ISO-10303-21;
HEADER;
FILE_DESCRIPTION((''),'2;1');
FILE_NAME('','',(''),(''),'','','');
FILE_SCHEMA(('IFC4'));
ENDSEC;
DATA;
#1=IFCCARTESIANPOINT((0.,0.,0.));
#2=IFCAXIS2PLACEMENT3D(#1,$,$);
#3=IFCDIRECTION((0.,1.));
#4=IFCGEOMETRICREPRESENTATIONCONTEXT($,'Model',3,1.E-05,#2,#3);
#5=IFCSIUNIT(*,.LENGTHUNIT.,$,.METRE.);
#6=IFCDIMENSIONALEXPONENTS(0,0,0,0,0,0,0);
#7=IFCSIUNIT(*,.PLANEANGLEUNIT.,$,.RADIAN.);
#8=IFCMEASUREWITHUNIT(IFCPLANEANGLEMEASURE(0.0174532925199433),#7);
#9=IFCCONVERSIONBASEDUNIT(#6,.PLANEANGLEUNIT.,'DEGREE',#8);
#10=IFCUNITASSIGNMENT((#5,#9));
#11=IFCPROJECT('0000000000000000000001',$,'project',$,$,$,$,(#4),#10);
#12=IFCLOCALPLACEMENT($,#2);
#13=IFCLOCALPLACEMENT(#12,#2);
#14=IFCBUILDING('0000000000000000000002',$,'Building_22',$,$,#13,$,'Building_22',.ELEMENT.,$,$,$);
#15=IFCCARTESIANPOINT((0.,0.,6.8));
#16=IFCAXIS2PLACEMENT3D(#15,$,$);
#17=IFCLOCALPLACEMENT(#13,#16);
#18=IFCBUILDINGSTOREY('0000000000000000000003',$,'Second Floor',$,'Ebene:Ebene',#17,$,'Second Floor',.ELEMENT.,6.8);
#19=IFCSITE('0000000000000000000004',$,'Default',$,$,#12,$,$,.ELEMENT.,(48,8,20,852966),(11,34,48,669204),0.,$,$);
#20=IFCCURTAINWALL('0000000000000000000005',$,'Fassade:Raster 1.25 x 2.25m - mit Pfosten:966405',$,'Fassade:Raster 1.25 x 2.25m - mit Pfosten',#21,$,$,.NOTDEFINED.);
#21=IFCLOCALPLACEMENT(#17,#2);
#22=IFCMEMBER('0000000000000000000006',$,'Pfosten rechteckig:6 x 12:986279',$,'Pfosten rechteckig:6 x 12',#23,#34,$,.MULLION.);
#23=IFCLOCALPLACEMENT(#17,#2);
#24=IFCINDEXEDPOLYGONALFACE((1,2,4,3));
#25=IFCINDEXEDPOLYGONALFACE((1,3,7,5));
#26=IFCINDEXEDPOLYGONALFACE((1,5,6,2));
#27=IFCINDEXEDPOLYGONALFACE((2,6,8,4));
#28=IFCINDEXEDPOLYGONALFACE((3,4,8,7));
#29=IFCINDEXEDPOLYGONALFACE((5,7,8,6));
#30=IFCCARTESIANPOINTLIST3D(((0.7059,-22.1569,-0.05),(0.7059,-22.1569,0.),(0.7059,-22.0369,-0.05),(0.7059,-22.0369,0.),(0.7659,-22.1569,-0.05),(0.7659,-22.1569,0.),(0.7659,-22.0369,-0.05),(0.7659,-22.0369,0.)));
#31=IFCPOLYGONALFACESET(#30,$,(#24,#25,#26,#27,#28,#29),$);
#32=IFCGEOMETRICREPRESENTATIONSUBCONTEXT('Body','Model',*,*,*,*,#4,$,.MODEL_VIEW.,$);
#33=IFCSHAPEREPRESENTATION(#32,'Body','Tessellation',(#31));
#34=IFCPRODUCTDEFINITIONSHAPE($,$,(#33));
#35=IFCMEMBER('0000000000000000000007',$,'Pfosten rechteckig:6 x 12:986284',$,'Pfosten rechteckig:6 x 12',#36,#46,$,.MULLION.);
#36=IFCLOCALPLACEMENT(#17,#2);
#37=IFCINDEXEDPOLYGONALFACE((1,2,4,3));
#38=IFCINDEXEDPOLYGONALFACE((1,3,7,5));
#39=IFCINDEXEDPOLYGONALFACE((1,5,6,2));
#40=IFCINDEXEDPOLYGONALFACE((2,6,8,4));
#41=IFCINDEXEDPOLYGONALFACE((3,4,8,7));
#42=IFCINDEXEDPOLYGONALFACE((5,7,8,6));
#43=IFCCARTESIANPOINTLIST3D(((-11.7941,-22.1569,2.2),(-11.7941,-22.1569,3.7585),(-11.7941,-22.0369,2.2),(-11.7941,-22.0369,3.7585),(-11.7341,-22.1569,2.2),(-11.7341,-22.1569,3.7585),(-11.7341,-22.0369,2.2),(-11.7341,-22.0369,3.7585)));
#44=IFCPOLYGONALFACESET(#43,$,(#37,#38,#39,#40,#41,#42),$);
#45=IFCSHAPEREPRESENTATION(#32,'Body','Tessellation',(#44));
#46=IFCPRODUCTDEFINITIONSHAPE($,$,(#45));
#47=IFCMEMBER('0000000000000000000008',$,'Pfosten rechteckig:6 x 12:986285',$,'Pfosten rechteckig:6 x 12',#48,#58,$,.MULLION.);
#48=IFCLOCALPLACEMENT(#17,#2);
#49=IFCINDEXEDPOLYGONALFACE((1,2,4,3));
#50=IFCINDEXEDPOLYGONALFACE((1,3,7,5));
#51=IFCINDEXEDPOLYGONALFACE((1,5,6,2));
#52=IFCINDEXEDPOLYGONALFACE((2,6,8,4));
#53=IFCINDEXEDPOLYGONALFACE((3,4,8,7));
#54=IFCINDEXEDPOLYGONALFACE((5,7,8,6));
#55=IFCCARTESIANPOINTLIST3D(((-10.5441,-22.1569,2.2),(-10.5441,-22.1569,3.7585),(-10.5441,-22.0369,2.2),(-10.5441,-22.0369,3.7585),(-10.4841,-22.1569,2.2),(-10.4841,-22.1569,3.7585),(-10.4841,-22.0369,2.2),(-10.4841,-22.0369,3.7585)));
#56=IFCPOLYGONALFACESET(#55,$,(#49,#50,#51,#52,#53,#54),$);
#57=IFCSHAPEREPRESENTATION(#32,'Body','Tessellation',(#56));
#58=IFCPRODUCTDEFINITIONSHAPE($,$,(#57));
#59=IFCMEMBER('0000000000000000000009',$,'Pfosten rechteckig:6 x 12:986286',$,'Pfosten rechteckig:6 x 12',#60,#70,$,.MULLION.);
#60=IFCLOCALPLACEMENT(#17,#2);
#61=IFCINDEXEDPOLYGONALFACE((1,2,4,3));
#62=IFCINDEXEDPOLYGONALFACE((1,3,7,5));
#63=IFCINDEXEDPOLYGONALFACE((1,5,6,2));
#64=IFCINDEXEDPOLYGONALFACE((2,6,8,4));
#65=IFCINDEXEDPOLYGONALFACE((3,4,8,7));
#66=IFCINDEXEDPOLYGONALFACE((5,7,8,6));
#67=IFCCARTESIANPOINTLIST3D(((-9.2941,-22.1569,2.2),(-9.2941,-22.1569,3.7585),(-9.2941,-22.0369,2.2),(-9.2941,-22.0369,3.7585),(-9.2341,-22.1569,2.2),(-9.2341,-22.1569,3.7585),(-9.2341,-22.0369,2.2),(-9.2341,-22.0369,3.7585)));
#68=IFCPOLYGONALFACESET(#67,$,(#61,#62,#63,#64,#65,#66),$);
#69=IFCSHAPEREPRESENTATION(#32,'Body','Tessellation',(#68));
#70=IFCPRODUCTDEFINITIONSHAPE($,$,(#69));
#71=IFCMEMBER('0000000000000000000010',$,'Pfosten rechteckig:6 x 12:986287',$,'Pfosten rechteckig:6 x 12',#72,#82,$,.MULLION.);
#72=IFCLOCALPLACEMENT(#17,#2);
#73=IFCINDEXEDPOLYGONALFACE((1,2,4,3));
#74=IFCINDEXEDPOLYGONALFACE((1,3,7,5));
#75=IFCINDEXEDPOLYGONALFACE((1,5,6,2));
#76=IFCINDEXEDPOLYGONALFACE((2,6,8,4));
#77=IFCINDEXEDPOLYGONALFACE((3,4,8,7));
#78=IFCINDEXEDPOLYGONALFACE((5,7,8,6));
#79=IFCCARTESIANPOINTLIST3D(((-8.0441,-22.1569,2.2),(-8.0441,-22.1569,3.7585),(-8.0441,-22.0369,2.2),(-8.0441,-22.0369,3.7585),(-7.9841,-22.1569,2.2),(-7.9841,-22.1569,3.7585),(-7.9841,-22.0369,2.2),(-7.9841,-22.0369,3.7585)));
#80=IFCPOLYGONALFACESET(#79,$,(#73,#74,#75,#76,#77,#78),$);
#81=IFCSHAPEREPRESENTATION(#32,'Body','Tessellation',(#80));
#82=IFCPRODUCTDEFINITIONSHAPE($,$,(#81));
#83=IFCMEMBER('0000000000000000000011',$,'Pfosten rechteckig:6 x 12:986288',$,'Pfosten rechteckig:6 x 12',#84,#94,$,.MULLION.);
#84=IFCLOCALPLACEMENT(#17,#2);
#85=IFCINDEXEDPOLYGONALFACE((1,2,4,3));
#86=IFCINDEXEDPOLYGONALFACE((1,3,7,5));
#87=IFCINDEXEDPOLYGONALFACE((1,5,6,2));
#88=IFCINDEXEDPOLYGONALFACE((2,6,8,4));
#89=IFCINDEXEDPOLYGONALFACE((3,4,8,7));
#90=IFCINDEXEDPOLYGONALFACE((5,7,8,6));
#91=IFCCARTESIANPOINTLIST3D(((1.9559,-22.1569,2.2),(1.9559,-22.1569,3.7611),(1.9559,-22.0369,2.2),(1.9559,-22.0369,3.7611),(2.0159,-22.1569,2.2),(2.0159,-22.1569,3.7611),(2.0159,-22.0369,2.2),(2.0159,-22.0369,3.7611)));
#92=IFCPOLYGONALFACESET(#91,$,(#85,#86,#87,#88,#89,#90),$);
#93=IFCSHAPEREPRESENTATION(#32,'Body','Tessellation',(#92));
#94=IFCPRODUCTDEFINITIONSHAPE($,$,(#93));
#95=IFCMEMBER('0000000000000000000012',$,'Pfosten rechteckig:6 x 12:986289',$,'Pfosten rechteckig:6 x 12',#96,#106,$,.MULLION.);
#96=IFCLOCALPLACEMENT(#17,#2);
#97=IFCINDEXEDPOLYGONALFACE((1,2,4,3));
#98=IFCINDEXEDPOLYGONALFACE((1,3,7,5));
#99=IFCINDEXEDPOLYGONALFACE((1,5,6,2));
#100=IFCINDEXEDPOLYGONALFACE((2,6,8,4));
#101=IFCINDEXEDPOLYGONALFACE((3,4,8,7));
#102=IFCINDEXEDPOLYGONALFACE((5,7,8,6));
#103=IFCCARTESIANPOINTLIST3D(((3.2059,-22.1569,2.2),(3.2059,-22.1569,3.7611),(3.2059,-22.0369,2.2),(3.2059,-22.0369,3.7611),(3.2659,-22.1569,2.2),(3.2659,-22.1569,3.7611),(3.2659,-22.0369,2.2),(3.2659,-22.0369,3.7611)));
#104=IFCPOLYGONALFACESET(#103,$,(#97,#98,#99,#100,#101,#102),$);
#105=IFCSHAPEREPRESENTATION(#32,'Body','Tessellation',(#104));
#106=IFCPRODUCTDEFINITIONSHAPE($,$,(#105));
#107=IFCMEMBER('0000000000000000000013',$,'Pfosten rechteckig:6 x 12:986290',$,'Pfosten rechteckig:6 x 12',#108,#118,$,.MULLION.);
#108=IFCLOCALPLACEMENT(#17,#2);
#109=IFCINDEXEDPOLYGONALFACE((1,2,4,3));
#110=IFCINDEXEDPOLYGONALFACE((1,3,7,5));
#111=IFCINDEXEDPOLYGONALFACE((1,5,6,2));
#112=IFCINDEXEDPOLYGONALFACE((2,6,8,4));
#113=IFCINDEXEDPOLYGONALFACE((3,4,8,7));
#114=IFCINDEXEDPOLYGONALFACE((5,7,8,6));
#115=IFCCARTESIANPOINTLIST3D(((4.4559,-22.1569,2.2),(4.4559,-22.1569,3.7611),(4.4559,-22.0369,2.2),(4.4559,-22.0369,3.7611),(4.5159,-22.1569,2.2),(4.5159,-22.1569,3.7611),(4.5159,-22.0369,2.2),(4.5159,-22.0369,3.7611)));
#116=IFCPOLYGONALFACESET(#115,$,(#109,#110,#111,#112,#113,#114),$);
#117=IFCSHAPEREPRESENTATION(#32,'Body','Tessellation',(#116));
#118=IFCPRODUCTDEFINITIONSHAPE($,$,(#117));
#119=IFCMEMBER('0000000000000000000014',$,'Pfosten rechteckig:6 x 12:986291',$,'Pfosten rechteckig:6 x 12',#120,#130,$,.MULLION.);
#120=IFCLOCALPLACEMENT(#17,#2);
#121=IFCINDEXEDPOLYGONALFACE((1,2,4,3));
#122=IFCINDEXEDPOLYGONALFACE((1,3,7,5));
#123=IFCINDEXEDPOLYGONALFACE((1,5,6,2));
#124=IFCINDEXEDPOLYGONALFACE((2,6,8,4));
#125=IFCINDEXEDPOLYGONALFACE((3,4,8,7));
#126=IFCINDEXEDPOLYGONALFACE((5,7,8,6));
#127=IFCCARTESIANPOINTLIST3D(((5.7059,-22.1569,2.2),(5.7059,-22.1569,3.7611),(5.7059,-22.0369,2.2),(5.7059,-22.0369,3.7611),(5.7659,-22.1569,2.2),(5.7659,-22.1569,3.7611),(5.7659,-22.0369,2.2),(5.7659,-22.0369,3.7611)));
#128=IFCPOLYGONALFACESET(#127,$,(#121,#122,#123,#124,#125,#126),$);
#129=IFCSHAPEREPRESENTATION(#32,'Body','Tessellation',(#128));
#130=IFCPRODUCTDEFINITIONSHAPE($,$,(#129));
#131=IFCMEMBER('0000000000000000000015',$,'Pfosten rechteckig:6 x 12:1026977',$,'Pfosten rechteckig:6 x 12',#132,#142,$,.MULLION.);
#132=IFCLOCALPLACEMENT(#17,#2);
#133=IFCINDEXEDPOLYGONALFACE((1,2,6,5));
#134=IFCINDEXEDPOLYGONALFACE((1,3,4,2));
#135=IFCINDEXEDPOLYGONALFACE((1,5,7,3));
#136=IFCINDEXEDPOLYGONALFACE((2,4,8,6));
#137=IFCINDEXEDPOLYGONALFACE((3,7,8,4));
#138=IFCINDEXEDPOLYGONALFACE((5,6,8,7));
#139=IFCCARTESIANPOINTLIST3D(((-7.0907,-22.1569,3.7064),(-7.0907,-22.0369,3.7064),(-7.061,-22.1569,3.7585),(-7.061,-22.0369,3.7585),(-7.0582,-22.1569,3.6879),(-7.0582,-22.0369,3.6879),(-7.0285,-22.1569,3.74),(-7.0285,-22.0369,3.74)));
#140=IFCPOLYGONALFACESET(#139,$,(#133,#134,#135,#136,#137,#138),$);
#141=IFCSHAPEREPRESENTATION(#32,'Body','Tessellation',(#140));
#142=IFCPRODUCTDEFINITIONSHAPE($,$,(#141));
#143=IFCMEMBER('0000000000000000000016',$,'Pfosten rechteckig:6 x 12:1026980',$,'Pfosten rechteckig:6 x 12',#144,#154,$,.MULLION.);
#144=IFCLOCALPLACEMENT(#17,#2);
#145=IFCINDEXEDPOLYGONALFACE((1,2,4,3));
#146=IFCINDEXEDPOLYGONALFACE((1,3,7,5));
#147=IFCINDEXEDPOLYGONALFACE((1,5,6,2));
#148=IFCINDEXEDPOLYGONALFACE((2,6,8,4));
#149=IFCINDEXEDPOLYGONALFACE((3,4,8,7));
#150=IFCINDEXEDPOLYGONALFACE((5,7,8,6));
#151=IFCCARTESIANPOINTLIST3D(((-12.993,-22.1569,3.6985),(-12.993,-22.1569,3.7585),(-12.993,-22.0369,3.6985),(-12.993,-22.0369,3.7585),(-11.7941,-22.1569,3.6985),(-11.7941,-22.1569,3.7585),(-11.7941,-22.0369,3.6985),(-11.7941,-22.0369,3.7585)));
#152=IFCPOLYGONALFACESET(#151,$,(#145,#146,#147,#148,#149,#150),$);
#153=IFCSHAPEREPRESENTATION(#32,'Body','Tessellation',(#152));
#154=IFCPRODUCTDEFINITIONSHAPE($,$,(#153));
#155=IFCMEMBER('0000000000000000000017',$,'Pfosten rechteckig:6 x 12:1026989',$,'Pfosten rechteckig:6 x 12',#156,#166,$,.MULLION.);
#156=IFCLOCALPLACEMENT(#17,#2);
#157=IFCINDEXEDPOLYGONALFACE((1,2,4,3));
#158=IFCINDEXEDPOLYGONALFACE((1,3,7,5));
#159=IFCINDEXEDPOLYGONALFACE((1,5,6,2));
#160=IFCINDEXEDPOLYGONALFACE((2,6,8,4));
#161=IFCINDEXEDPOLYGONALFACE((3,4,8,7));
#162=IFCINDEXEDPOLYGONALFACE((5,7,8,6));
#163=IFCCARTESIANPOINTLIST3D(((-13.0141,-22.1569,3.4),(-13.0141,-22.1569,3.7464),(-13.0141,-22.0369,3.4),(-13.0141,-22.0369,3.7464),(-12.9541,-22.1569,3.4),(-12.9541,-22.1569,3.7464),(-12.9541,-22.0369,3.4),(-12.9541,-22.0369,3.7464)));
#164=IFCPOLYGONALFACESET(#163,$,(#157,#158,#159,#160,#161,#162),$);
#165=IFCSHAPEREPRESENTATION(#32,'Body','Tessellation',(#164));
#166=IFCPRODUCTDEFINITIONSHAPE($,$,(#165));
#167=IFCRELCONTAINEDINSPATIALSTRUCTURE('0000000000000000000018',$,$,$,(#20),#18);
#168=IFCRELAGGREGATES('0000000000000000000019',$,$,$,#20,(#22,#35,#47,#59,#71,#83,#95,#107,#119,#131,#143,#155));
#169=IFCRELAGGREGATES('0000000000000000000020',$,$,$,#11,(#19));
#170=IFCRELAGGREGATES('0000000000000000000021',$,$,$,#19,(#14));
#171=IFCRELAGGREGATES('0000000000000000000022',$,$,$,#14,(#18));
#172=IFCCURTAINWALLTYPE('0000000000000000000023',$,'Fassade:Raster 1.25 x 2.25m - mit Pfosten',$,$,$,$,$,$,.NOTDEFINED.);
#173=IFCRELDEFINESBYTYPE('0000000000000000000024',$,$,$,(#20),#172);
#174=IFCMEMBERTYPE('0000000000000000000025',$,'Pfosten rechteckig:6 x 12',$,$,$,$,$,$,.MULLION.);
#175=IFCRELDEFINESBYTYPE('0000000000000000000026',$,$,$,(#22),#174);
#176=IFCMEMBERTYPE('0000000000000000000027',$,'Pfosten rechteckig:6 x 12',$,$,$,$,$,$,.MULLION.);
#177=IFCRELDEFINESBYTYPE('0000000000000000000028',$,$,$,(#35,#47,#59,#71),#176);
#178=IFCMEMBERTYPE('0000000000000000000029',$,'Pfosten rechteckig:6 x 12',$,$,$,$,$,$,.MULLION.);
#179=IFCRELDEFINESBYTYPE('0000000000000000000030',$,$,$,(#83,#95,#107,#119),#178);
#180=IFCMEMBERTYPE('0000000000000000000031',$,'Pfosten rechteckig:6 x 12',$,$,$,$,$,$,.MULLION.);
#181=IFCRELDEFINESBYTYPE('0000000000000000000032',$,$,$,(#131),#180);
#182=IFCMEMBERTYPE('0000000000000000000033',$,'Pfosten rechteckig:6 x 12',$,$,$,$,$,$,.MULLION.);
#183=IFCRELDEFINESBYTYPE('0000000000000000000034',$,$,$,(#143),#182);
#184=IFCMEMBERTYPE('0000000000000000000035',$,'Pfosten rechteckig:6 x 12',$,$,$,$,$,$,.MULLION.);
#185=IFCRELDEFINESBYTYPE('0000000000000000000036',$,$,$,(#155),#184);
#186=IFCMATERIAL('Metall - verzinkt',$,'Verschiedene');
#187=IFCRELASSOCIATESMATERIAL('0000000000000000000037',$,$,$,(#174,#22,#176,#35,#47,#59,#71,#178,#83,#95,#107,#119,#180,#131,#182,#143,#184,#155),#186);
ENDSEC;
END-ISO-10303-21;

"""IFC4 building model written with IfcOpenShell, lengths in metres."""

from ifc_helpers import new_model, entity, si_unit, converted_unit, direction, frame, origin, place, context, subcontext, project, spatial, indexed_curve, outline, extrude, source, transform, mapped, material, type_object, type_shapes, element, aggregate, save


model = new_model("IFC4")

# Units and contexts
model_context = context("Model", 3, precision=1e-05, world=origin(), true_north=direction((0.0, 1.0)))
body_context = subcontext(model_context, "Body", "Model", "MODEL_VIEW")
ifc_project = project(units=[si_unit("LENGTHUNIT", "METRE"), converted_unit("PLANEANGLEUNIT", "DEGREE", entity("IfcPlaneAngleMeasure", 0.0174532925199433), si_unit("PLANEANGLEUNIT", "RADIAN"), dimensions=[0, 0, 0, 0, 0, 0, 0])], contexts=[model_context])

# Site, building, storey
site_placement = place(None, origin())
site = spatial("IfcSite", under=ifc_project, at=site_placement, Name="Default", CompositionType="ELEMENT", RefLatitude=(48, 8, 20, 852966), RefLongitude=(11, 34, 48, 669204), RefElevation=0.0)
building_placement = place(site_placement, origin())
building = spatial("IfcBuilding", under=site, at=building_placement, Name="Building_22", LongName="Building_22", CompositionType="ELEMENT")
storey_placement = place(building_placement, frame((0.0, 0.0, 6.8)))
storey = spatial("IfcBuildingStorey", under=building, at=storey_placement, Name="Second Floor", ObjectType="Ebene:Ebene", LongName="Second Floor", CompositionType="ELEMENT", Elevation=6.8)

# Curtain wall, members
curtain_wall_type = type_object("IfcCurtainWallType", Name="Fassade:Raster 1.25 x 2.25m - mit Pfosten", PredefinedType="NOTDEFINED")
curtain_wall_placement = place(storey_placement, frame((0.0, 0.0, -6.8)))
curtain_wall = element("IfcCurtainWall", 1, at=curtain_wall_placement, inside=storey, type_object=curtain_wall_type, Name="Fassade:Raster 1.25 x 2.25m - mit Pfosten:966405", ObjectType="Fassade:Raster 1.25 x 2.25m - mit Pfosten", PredefinedType="NOTDEFINED")
ifc_material = material(Name="Metall - verzinkt", Category="Verschiedene")
member_type_1 = type_object("IfcMemberType", Name="Pfosten rechteckig:6 x 12", PredefinedType="MULLION", material=ifc_material)
shared_shape_1 = source(origin(), body_context, "Body", "SweptSolid", [
    extrude(outline(indexed_curve([(-0.03, -0.06), (0.03, -0.06), (0.03, 0.06), (-0.03, 0.06), (-0.03, -0.06)], self_intersect=False)), frame((0.0, 0.0, -0.05), z_axis=(0.0, 0.0, 1.0), x_axis=(-1.0, 0.0, 0.0)), (0.0, 0.0, 1.0), 0.05),
])
type_shapes(member_type_1, [shared_shape_1])
member_1_placement = place(curtain_wall_placement, frame((0.7359, -22.0969, 6.75), z_axis=(0.0, 0.0, -1.0), x_axis=(1.0, 0.0, 0.0)))
member_1 = element("IfcMember", 2, at=member_1_placement, type_object=member_type_1, material=ifc_material, Name="Pfosten rechteckig:6 x 12:986279", ObjectType="Pfosten rechteckig:6 x 12", PredefinedType="MULLION", context=body_context, shape_type="MappedRepresentation", body=[
    mapped(shared_shape_1, transform((0.0, 0.0, 0.0), scale=1.0)),
])
member_type_2 = type_object("IfcMemberType", Name="Pfosten rechteckig:6 x 12", PredefinedType="MULLION", material=ifc_material)
shared_shape_2 = source(origin(), body_context, "Body", "SweptSolid", [
    extrude(outline(indexed_curve([(-0.03, -0.06), (0.03, -0.06), (0.03, 0.06), (-0.03, 0.06), (-0.03, -0.06)], self_intersect=False)), frame((0.0, 0.0, -1.5585), z_axis=(0.0, 0.0, 1.0), x_axis=(-1.0, 0.0, 0.0)), (0.0, 0.0, 1.0), 1.5585),
])
type_shapes(member_type_2, [shared_shape_2])
member_2_placement = place(curtain_wall_placement, frame((-11.7641, -22.0969, 9.0), z_axis=(0.0, 0.0, -1.0), x_axis=(1.0, 0.0, 0.0)))
member_2 = element("IfcMember", 3, at=member_2_placement, type_object=member_type_2, material=ifc_material, Name="Pfosten rechteckig:6 x 12:986284", ObjectType="Pfosten rechteckig:6 x 12", PredefinedType="MULLION", context=body_context, shape_type="MappedRepresentation", body=[
    mapped(shared_shape_2, transform((0.0, 0.0, 0.0), scale=1.0)),
])
member_3_placement = place(curtain_wall_placement, frame((-10.5141, -22.0969, 9.0), z_axis=(0.0, 0.0, -1.0), x_axis=(1.0, 0.0, 0.0)))
member_3 = element("IfcMember", 4, at=member_3_placement, type_object=member_type_2, material=ifc_material, Name="Pfosten rechteckig:6 x 12:986285", ObjectType="Pfosten rechteckig:6 x 12", PredefinedType="MULLION", context=body_context, shape_type="MappedRepresentation", body=[
    mapped(shared_shape_2, transform((0.0, 0.0, 0.0), scale=1.0)),
])
member_4_placement = place(curtain_wall_placement, frame((-9.2641, -22.0969, 9.0), z_axis=(0.0, 0.0, -1.0), x_axis=(1.0, 0.0, 0.0)))
member_4 = element("IfcMember", 5, at=member_4_placement, type_object=member_type_2, material=ifc_material, Name="Pfosten rechteckig:6 x 12:986286", ObjectType="Pfosten rechteckig:6 x 12", PredefinedType="MULLION", context=body_context, shape_type="MappedRepresentation", body=[
    mapped(shared_shape_2, transform((0.0, 0.0, 0.0), scale=1.0)),
])
member_5_placement = place(curtain_wall_placement, frame((-8.0141, -22.0969, 9.0), z_axis=(0.0, 0.0, -1.0), x_axis=(1.0, 0.0, 0.0)))
member_5 = element("IfcMember", 6, at=member_5_placement, type_object=member_type_2, material=ifc_material, Name="Pfosten rechteckig:6 x 12:986287", ObjectType="Pfosten rechteckig:6 x 12", PredefinedType="MULLION", context=body_context, shape_type="MappedRepresentation", body=[
    mapped(shared_shape_2, transform((0.0, 0.0, 0.0), scale=1.0)),
])
member_type_3 = type_object("IfcMemberType", Name="Pfosten rechteckig:6 x 12", PredefinedType="MULLION", material=ifc_material)
shared_shape_3 = source(origin(), body_context, "Body", "SweptSolid", [
    extrude(outline(indexed_curve([(-0.03, -0.06), (0.03, -0.06), (0.03, 0.06), (-0.03, 0.06), (-0.03, -0.06)], self_intersect=False)), frame((0.0, 0.0, -1.5611), z_axis=(0.0, 0.0, 1.0), x_axis=(-1.0, 0.0, 0.0)), (0.0, 0.0, 1.0), 1.5611),
])
type_shapes(member_type_3, [shared_shape_3])
member_6_placement = place(curtain_wall_placement, frame((1.9859, -22.0969, 9.0), z_axis=(0.0, 0.0, -1.0), x_axis=(1.0, 0.0, 0.0)))
member_6 = element("IfcMember", 7, at=member_6_placement, type_object=member_type_3, material=ifc_material, Name="Pfosten rechteckig:6 x 12:986288", ObjectType="Pfosten rechteckig:6 x 12", PredefinedType="MULLION", context=body_context, shape_type="MappedRepresentation", body=[
    mapped(shared_shape_3, transform((0.0, 0.0, 0.0), scale=1.0)),
])
member_7_placement = place(curtain_wall_placement, frame((3.2359, -22.0969, 9.0), z_axis=(0.0, 0.0, -1.0), x_axis=(1.0, 0.0, 0.0)))
member_7 = element("IfcMember", 8, at=member_7_placement, type_object=member_type_3, material=ifc_material, Name="Pfosten rechteckig:6 x 12:986289", ObjectType="Pfosten rechteckig:6 x 12", PredefinedType="MULLION", context=body_context, shape_type="MappedRepresentation", body=[
    mapped(shared_shape_3, transform((0.0, 0.0, 0.0), scale=1.0)),
])
member_8_placement = place(curtain_wall_placement, frame((4.4859, -22.0969, 9.0), z_axis=(0.0, 0.0, -1.0), x_axis=(1.0, 0.0, 0.0)))
member_8 = element("IfcMember", 9, at=member_8_placement, type_object=member_type_3, material=ifc_material, Name="Pfosten rechteckig:6 x 12:986290", ObjectType="Pfosten rechteckig:6 x 12", PredefinedType="MULLION", context=body_context, shape_type="MappedRepresentation", body=[
    mapped(shared_shape_3, transform((0.0, 0.0, 0.0), scale=1.0)),
])
member_9_placement = place(curtain_wall_placement, frame((5.7359, -22.0969, 9.0), z_axis=(0.0, 0.0, -1.0), x_axis=(1.0, 0.0, 0.0)))
member_9 = element("IfcMember", 10, at=member_9_placement, type_object=member_type_3, material=ifc_material, Name="Pfosten rechteckig:6 x 12:986291", ObjectType="Pfosten rechteckig:6 x 12", PredefinedType="MULLION", context=body_context, shape_type="MappedRepresentation", body=[
    mapped(shared_shape_3, transform((0.0, 0.0, 0.0), scale=1.0)),
])
member_type_4 = type_object("IfcMemberType", Name="Pfosten rechteckig:6 x 12", PredefinedType="MULLION", material=ifc_material)
shared_shape_4 = source(origin(), body_context, "Body", "SweptSolid", [
    extrude(outline(indexed_curve([(-0.03, -0.06), (0.03, -0.06), (0.03, 0.06), (-0.03, 0.06), (-0.03, -0.06)], self_intersect=False)), frame((-0.03, 0.0, -0.0374), z_axis=(0.0, 0.0, 1.0), x_axis=(-1.0, 0.0, 0.0)), (0.0, 0.0, 1.0), 0.0374),
])
type_shapes(member_type_4, [shared_shape_4])
member_10_placement = place(curtain_wall_placement, frame((-7.0285, -22.0969, 10.54), z_axis=(0.868526, 0.0, -0.495643), x_axis=(0.495643, 0.0, 0.868526)))
member_10 = element("IfcMember", 11, at=member_10_placement, type_object=member_type_4, material=ifc_material, Name="Pfosten rechteckig:6 x 12:1026977", ObjectType="Pfosten rechteckig:6 x 12", PredefinedType="MULLION", context=body_context, shape_type="MappedRepresentation", body=[
    mapped(shared_shape_4, transform((0.0, 0.0, 0.0), scale=1.0)),
])
member_type_5 = type_object("IfcMemberType", Name="Pfosten rechteckig:6 x 12", PredefinedType="MULLION", material=ifc_material)
shared_shape_5 = source(origin(), body_context, "Body", "SweptSolid", [
    extrude(outline(indexed_curve([(-0.03, -0.06), (0.03, -0.06), (0.03, 0.06), (-0.03, 0.06), (-0.03, -0.06)], self_intersect=False)), frame((-0.03, 0.0, -1.199), z_axis=(0.0, 0.0, 1.0), x_axis=(-1.0, 0.0, 0.0)), (0.0, 0.0, 1.0), 1.199),
])
type_shapes(member_type_5, [shared_shape_5])
member_11_placement = place(curtain_wall_placement, frame((-11.7941, -22.0969, 10.5585), z_axis=(1.0, 0.0, 0.0), x_axis=(0.0, 0.0, 1.0)))
member_11 = element("IfcMember", 12, at=member_11_placement, type_object=member_type_5, material=ifc_material, Name="Pfosten rechteckig:6 x 12:1026980", ObjectType="Pfosten rechteckig:6 x 12", PredefinedType="MULLION", context=body_context, shape_type="MappedRepresentation", body=[
    mapped(shared_shape_5, transform((0.0, 0.0, 0.0), scale=1.0)),
])
member_type_6 = type_object("IfcMemberType", Name="Pfosten rechteckig:6 x 12", PredefinedType="MULLION", material=ifc_material)
shared_shape_6 = source(origin(), body_context, "Body", "SweptSolid", [
    extrude(outline(indexed_curve([(-0.03, -0.06), (0.03, -0.06), (0.03, 0.06), (-0.03, 0.06), (-0.03, -0.06)], self_intersect=False)), frame((-0.03, 0.0, -0.3464), z_axis=(0.0, 0.0, 1.0), x_axis=(-1.0, 0.0, 0.0)), (0.0, 0.0, 1.0), 0.3464),
])
type_shapes(member_type_6, [shared_shape_6])
member_12_placement = place(curtain_wall_placement, frame((-13.0141, -22.0969, 10.5464), z_axis=(0.0, 0.0, 1.0), x_axis=(-1.0, 0.0, 0.0)))
member_12 = element("IfcMember", 13, at=member_12_placement, type_object=member_type_6, material=ifc_material, Name="Pfosten rechteckig:6 x 12:1026989", ObjectType="Pfosten rechteckig:6 x 12", PredefinedType="MULLION", context=body_context, shape_type="MappedRepresentation", body=[
    mapped(shared_shape_6, transform((0.0, 0.0, 0.0), scale=1.0)),
])
aggregate(curtain_wall, [member_1, member_2, member_3, member_4, member_5, member_6, member_7, member_8, member_9, member_10, member_11, member_12])

save(model, "model.ifc")
